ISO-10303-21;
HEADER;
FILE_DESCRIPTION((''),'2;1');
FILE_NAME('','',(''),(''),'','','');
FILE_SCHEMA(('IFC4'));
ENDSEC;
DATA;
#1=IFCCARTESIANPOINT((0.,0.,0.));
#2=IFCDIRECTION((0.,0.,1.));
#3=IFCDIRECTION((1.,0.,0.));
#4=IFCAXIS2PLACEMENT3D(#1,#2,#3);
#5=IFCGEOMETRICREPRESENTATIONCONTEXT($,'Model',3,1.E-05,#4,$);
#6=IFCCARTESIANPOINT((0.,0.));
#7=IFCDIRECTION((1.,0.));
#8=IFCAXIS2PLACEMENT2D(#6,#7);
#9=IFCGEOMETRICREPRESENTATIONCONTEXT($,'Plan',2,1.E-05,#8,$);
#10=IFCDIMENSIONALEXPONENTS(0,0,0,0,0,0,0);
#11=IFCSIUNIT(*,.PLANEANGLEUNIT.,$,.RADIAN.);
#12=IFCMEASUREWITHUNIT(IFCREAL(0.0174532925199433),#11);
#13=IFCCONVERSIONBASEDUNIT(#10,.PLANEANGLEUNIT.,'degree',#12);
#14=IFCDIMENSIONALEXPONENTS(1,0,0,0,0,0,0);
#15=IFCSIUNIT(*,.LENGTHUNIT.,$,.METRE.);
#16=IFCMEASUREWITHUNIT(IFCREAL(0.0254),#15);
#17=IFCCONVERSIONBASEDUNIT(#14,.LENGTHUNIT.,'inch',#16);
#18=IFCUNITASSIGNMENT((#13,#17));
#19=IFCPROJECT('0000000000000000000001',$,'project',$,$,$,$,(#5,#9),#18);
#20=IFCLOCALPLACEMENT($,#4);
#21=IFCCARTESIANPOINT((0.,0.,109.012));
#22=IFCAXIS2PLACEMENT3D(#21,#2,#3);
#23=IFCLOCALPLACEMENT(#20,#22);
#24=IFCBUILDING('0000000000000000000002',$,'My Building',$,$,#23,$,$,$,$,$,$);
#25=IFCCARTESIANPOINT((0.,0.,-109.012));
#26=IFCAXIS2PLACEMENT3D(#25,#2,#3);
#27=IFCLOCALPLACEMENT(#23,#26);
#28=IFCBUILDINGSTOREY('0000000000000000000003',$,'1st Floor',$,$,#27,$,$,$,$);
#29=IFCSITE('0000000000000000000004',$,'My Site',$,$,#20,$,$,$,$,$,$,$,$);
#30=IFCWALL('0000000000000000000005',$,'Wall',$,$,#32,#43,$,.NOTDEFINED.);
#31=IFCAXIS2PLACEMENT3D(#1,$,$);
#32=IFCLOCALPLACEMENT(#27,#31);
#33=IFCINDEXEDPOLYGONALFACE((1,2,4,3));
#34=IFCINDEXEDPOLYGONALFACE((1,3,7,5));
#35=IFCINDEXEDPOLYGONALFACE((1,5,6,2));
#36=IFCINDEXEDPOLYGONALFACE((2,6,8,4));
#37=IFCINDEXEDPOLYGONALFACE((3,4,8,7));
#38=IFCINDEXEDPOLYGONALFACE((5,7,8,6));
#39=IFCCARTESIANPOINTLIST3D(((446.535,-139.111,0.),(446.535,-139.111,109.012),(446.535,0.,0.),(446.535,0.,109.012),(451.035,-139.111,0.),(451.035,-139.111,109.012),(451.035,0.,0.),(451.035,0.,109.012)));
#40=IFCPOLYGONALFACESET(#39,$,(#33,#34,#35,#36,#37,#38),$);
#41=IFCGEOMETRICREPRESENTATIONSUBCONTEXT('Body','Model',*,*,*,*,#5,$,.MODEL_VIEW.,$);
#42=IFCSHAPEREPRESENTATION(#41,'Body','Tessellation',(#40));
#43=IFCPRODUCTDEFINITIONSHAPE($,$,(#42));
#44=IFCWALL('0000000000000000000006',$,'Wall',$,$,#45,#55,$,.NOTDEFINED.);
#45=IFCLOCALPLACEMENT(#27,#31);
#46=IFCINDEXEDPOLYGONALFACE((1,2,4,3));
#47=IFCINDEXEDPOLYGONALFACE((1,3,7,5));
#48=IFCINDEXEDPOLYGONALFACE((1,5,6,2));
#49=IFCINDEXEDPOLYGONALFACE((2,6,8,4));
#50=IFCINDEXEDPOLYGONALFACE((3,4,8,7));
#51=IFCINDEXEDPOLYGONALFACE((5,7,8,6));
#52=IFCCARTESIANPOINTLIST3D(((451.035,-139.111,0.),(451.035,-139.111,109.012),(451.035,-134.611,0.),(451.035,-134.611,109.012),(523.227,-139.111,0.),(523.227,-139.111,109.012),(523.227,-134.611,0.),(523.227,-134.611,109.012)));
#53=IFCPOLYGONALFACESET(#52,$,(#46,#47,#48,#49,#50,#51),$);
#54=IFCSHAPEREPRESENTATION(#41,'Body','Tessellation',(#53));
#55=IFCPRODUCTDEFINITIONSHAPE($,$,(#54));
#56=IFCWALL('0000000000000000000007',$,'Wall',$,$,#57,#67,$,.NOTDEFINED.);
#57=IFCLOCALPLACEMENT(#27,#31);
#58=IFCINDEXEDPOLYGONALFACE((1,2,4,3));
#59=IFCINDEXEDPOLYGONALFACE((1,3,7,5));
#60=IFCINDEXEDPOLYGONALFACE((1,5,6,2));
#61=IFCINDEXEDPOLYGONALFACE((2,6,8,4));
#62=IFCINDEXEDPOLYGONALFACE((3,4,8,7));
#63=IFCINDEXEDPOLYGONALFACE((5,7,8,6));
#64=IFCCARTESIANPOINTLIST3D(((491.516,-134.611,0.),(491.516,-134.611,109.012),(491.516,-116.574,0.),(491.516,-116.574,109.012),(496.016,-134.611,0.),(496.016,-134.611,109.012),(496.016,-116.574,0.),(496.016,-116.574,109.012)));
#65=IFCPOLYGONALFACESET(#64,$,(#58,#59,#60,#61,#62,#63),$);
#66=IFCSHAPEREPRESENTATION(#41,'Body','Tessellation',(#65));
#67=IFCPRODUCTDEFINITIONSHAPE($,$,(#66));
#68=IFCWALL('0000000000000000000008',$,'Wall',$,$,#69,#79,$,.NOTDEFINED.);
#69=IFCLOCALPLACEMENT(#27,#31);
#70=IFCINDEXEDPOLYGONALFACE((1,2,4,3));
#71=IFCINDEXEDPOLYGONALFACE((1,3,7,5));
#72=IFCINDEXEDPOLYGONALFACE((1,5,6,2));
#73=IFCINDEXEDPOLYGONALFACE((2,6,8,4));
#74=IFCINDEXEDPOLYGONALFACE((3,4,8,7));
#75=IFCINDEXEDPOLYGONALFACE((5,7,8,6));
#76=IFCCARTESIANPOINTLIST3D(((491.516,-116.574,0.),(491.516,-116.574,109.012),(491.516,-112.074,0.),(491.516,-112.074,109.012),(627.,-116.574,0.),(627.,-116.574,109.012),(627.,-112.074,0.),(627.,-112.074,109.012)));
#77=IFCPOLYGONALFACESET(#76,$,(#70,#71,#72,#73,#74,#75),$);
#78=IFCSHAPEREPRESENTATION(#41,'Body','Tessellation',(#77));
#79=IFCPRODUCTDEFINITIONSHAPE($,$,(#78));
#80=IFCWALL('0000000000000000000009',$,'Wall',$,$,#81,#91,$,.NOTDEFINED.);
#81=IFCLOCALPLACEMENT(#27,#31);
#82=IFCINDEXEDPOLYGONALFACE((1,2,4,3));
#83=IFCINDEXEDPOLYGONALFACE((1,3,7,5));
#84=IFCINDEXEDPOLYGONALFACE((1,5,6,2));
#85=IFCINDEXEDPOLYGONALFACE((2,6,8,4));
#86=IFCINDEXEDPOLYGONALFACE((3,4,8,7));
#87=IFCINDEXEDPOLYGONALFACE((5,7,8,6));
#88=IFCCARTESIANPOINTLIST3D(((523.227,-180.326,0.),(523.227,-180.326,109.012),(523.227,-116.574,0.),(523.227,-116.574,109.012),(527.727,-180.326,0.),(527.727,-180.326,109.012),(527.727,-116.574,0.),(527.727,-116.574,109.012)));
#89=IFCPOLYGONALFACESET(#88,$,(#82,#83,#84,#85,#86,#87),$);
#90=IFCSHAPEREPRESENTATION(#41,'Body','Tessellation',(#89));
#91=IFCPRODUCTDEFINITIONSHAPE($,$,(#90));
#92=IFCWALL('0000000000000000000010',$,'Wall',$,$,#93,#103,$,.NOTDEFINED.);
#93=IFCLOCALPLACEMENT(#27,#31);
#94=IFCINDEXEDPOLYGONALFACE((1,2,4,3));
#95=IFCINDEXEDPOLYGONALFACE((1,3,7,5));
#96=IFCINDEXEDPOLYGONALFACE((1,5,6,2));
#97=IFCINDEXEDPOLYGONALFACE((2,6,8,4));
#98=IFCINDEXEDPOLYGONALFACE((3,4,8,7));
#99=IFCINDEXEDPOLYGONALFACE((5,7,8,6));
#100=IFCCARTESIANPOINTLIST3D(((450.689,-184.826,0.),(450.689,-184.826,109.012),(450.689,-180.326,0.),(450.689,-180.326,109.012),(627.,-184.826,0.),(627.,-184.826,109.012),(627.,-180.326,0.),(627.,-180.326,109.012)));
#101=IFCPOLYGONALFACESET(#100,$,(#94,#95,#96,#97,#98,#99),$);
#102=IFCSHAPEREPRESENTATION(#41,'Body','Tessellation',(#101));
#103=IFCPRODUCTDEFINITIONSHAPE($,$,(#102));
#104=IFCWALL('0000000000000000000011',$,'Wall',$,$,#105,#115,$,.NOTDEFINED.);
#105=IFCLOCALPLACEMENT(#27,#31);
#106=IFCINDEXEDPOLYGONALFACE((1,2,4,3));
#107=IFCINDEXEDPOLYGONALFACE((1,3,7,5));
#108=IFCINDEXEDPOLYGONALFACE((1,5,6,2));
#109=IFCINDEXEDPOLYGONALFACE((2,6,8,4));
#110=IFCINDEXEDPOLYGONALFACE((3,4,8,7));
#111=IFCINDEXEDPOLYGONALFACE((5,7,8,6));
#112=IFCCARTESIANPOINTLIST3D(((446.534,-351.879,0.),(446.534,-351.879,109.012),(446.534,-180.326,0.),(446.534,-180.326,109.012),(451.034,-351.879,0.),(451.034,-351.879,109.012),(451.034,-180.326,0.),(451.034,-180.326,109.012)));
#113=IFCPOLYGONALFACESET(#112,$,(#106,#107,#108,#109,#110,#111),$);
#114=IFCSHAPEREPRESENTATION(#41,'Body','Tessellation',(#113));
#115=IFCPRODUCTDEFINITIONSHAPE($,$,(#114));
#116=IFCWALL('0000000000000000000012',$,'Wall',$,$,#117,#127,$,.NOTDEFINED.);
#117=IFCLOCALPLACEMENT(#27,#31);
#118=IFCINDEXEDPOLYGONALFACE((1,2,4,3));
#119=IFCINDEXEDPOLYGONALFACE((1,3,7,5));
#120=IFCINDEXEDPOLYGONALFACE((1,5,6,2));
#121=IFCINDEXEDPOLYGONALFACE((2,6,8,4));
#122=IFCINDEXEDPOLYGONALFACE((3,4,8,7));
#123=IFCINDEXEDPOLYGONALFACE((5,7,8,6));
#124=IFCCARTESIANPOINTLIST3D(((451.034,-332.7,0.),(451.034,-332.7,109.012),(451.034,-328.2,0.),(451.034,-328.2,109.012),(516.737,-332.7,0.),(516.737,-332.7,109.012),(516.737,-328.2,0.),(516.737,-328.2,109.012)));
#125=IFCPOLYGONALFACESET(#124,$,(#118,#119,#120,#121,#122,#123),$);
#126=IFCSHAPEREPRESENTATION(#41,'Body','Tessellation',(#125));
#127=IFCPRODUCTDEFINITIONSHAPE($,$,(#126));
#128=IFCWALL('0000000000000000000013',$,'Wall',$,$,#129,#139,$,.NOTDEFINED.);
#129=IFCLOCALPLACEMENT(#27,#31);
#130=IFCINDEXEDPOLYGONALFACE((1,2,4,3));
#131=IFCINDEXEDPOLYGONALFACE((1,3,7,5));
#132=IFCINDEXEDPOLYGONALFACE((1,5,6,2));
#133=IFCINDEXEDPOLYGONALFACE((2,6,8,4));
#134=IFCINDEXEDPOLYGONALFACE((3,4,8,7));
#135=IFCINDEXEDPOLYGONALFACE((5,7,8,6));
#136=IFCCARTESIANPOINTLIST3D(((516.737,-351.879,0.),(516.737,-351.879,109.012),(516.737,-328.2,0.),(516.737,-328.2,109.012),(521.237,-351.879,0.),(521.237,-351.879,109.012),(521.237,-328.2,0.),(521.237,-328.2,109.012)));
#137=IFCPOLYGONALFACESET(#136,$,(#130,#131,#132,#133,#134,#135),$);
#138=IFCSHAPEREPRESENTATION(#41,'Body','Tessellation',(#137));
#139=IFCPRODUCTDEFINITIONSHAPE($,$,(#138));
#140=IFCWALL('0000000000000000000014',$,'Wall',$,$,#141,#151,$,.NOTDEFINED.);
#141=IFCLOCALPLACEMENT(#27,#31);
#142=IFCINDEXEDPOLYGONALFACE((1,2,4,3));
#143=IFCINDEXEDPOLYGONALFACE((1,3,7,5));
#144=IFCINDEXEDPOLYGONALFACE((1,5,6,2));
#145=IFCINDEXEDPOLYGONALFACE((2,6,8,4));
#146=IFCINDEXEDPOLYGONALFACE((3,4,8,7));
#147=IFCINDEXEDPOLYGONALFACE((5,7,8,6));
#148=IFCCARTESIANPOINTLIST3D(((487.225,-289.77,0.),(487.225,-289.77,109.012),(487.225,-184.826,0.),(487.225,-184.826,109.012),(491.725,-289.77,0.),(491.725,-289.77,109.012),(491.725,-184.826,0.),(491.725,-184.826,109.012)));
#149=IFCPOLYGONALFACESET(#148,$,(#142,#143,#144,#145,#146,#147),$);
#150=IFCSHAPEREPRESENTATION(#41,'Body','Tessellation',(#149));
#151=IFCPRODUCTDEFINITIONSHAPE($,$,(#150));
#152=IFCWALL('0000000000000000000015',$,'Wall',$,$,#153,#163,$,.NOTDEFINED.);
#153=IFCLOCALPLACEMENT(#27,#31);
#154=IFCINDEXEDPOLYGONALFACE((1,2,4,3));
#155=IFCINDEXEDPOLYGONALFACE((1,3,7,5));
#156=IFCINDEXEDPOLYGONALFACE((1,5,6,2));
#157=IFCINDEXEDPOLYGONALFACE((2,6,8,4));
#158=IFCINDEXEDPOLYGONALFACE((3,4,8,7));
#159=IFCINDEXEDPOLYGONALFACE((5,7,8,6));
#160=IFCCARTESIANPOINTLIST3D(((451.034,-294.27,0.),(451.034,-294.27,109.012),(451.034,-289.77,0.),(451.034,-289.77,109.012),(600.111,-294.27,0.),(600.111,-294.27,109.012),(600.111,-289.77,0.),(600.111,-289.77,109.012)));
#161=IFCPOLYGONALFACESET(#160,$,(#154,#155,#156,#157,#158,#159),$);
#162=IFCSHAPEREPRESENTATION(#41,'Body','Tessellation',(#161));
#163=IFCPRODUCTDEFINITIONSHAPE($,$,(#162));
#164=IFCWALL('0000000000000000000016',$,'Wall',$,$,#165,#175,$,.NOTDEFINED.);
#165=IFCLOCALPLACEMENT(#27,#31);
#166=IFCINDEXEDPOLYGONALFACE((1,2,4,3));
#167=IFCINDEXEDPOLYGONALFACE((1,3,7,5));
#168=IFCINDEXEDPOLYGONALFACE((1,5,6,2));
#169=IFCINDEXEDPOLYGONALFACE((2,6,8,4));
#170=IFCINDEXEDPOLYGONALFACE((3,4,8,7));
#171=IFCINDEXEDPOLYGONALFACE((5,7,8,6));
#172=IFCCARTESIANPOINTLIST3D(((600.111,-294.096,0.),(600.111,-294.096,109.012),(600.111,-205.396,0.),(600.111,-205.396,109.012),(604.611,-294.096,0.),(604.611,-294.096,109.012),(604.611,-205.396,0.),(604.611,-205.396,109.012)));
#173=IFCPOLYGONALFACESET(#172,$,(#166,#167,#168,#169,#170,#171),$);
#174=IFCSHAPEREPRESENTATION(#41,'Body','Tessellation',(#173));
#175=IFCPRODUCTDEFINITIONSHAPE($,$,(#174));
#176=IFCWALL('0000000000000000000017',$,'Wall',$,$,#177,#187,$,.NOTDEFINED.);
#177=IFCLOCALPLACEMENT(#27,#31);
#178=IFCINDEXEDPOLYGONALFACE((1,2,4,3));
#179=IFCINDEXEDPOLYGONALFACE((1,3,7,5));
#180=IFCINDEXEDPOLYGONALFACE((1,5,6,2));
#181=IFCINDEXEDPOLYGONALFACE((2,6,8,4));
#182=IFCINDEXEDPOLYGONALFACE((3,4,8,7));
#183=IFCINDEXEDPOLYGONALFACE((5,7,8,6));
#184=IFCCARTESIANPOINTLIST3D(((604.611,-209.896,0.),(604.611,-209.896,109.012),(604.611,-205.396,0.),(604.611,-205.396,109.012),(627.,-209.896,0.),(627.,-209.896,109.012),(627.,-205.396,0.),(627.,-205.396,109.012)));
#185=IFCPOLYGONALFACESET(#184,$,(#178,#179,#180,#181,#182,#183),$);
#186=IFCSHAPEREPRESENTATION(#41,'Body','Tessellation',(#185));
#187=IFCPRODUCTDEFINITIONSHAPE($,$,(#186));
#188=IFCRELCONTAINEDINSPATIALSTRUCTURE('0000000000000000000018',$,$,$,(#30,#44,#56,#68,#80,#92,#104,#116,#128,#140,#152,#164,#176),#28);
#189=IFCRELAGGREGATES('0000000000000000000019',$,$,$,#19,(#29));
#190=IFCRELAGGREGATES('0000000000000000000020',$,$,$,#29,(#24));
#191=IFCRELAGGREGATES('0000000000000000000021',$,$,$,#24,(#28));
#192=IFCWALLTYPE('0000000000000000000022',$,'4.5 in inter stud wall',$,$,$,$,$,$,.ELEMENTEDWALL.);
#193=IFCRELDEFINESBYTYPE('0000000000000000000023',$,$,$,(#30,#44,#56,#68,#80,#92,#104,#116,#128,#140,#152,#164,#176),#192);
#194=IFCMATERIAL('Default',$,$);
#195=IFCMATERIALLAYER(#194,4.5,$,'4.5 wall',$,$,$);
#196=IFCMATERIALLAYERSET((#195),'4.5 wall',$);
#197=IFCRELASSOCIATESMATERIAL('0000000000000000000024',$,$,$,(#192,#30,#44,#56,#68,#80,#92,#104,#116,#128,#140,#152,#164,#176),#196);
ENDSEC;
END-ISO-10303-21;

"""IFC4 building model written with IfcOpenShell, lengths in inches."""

from ifc_helpers import new_model, entity, si_unit, converted_unit, frame, origin_with_axes, origin_2d_with_axis, place, context, subcontext, project, spatial, indexed_curve, outline, extrude, material, layer, layer_set, layer_usage, type_object, element, save


model = new_model("IFC4")

# Units and contexts
model_context = context("Model", 3, precision=1e-05, world=origin_with_axes())
plan_context = context("Plan", 2, precision=1e-05, world=origin_2d_with_axis())
body_context = subcontext(model_context, "Body", "Model", "MODEL_VIEW")
ifc_project = project(units=[converted_unit("PLANEANGLEUNIT", "degree", entity("IfcReal", 0.0174532925199433), si_unit("PLANEANGLEUNIT", "RADIAN"), dimensions=[0, 0, 0, 0, 0, 0, 0]), converted_unit("LENGTHUNIT", "inch", entity("IfcReal", 0.0254), si_unit("LENGTHUNIT", "METRE"), dimensions=[1, 0, 0, 0, 0, 0, 0])], contexts=[model_context, plan_context])

# Site, building, storey
site_placement = place(None, origin_with_axes())
site = spatial("IfcSite", under=ifc_project, at=site_placement, Name="My Site")
building_placement = place(site_placement, frame((0.0, 0.0, 109.012), z_axis=(0.0, 0.0, 1.0), x_axis=(1.0, 0.0, 0.0)))
building = spatial("IfcBuilding", under=site, at=building_placement, Name="My Building")
storey_placement = place(building_placement, frame((0.0, 0.0, -109.012), z_axis=(0.0, 0.0, 1.0), x_axis=(1.0, 0.0, 0.0)))
storey = spatial("IfcBuildingStorey", under=building, at=storey_placement, Name="1st Floor")

# Shared definitions
ifc_material = material(Name="Default")

# Walls
ifc_layer_1 = layer(ifc_material, 4.5, Name="4.5 wall")
ifc_layer_set_1 = layer_set([ifc_layer_1], Name="4.5 wall")
ifc_layer_usage_1 = layer_usage(ifc_layer_set_1, "AXIS2", "POSITIVE", 0.0)
wall_type_1 = type_object("IfcWallType", Name="4.5 in inter stud wall", PredefinedType="ELEMENTEDWALL", material=ifc_layer_set_1)
wall_1_placement = place(storey_placement, frame((446.535, 0.0, 0.0), z_axis=(0.0, 0.0, 1.0), x_axis=(0.0, -1.0, 0.0)))
element("IfcWall", 1, at=wall_1_placement, inside=storey, type_object=wall_type_1, material=ifc_layer_usage_1, Name="Wall", PredefinedType="NOTDEFINED", context=body_context, shape_type="SweptSolid", body=[
    extrude(outline(indexed_curve([(0.0, 0.0), (0.0, 4.5), (139.111, 4.5), (139.111, 0.0), (0.0, 0.0)], self_intersect=False)), origin_with_axes(), (0.0, 0.0, 1.0), 109.012),
])
ifc_layer_usage_2 = layer_usage(ifc_layer_set_1, "AXIS2", "POSITIVE", 0.0)
wall_2_placement = place(storey_placement, frame((451.035, -139.111, 0.0), z_axis=(0.0, 0.0, 1.0), x_axis=(1.0, 0.0, 0.0)))
element("IfcWall", 2, at=wall_2_placement, inside=storey, type_object=wall_type_1, material=ifc_layer_usage_2, Name="Wall", PredefinedType="NOTDEFINED", context=body_context, shape_type="SweptSolid", body=[
    extrude(outline(indexed_curve([(0.0, 0.0), (0.0, 4.5), (72.192, 4.5), (72.192, 0.0), (0.0, 0.0)], self_intersect=False)), origin_with_axes(), (0.0, 0.0, 1.0), 109.012),
])
ifc_layer_usage_3 = layer_usage(ifc_layer_set_1, "AXIS2", "POSITIVE", 0.0)
wall_3_placement = place(storey_placement, frame((496.016, -134.611, 0.0), z_axis=(0.0, 0.0, 1.0), x_axis=(0.0, 1.0, 0.0)))
element("IfcWall", 3, at=wall_3_placement, inside=storey, type_object=wall_type_1, material=ifc_layer_usage_3, Name="Wall", PredefinedType="NOTDEFINED", context=body_context, shape_type="SweptSolid", body=[
    extrude(outline(indexed_curve([(0.0, 0.0), (0.0, 4.5), (18.037, 4.5), (18.037, 0.0), (0.0, 0.0)], self_intersect=False)), origin_with_axes(), (0.0, 0.0, 1.0), 109.012),
])
ifc_layer_usage_4 = layer_usage(ifc_layer_set_1, "AXIS2", "POSITIVE", 0.0)
wall_4_placement = place(storey_placement, frame((491.516, -116.574, 0.0), z_axis=(0.0, 0.0, 1.0), x_axis=(1.0, 0.0, 0.0)))
element("IfcWall", 4, at=wall_4_placement, inside=storey, type_object=wall_type_1, material=ifc_layer_usage_4, Name="Wall", PredefinedType="NOTDEFINED", context=body_context, shape_type="SweptSolid", body=[
    extrude(outline(indexed_curve([(0.0, 0.0), (0.0, 4.5), (135.484, 4.5), (135.484, 0.0), (0.0, 0.0)], self_intersect=False)), origin_with_axes(), (0.0, 0.0, 1.0), 109.012),
])
ifc_layer_usage_5 = layer_usage(ifc_layer_set_1, "AXIS2", "POSITIVE", 0.0)
wall_5_placement = place(storey_placement, frame((523.227, -116.574, 0.0), z_axis=(0.0, 0.0, 1.0), x_axis=(0.0, -1.0, 0.0)))
element("IfcWall", 5, at=wall_5_placement, inside=storey, type_object=wall_type_1, material=ifc_layer_usage_5, Name="Wall", PredefinedType="NOTDEFINED", context=body_context, shape_type="SweptSolid", body=[
    extrude(outline(indexed_curve([(0.0, 0.0), (0.0, 4.5), (63.752, 4.5), (63.752, 0.0), (0.0, 0.0)], self_intersect=False)), origin_with_axes(), (0.0, 0.0, 1.0), 109.012),
])
ifc_layer_usage_6 = layer_usage(ifc_layer_set_1, "AXIS2", "POSITIVE", 0.0)
wall_6_placement = place(storey_placement, frame((627.0, -180.326, 0.0), z_axis=(0.0, 0.0, 1.0), x_axis=(-1.0, 0.000001, 0.0)))
element("IfcWall", 6, at=wall_6_placement, inside=storey, type_object=wall_type_1, material=ifc_layer_usage_6, Name="Wall", PredefinedType="NOTDEFINED", context=body_context, shape_type="SweptSolid", body=[
    extrude(outline(indexed_curve([(0.0, 0.0), (0.0, 4.5), (176.311, 4.5), (176.311, 0.0), (0.0, 0.0)], self_intersect=False)), origin_with_axes(), (0.0, 0.0, 1.0), 109.012),
])
ifc_layer_usage_7 = layer_usage(ifc_layer_set_1, "AXIS2", "POSITIVE", 0.0)
wall_7_placement = place(storey_placement, frame((451.034, -351.879, 0.0), z_axis=(0.0, 0.0, 1.0), x_axis=(0.000001, 1.0, 0.0)))
element("IfcWall", 7, at=wall_7_placement, inside=storey, type_object=wall_type_1, material=ifc_layer_usage_7, Name="Wall", PredefinedType="NOTDEFINED", context=body_context, shape_type="SweptSolid", body=[
    extrude(outline(indexed_curve([(0.0, 0.0), (0.0, 4.5), (171.553, 4.5), (171.553, 0.0), (0.0, 0.0)], self_intersect=False)), origin_with_axes(), (0.0, 0.0, 1.0), 109.012),
])
ifc_layer_usage_8 = layer_usage(ifc_layer_set_1, "AXIS2", "POSITIVE", 0.0)
wall_8_placement = place(storey_placement, frame((516.737, -328.2, 0.0), z_axis=(0.0, 0.0, 1.0), x_axis=(-1.0, 0.000001, 0.0)))
element("IfcWall", 8, at=wall_8_placement, inside=storey, type_object=wall_type_1, material=ifc_layer_usage_8, Name="Wall", PredefinedType="NOTDEFINED", context=body_context, shape_type="SweptSolid", body=[
    extrude(outline(indexed_curve([(0.0, 0.0), (0.0, 4.5), (65.703, 4.5), (65.703, 0.0), (0.0, 0.0)], self_intersect=False)), origin_with_axes(), (0.0, 0.0, 1.0), 109.012),
])
ifc_layer_usage_9 = layer_usage(ifc_layer_set_1, "AXIS2", "POSITIVE", 0.0)
wall_9_placement = place(storey_placement, frame((516.737, -328.2, 0.0), z_axis=(0.0, 0.0, 1.0), x_axis=(-0.000001, -1.0, 0.0)))
element("IfcWall", 9, at=wall_9_placement, inside=storey, type_object=wall_type_1, material=ifc_layer_usage_9, Name="Wall", PredefinedType="NOTDEFINED", context=body_context, shape_type="SweptSolid", body=[
    extrude(outline(indexed_curve([(0.0, 0.0), (0.0, 4.5), (23.679, 4.5), (23.679, 0.0), (0.0, 0.0)], self_intersect=False)), origin_with_axes(), (0.0, 0.0, 1.0), 109.012),
])
ifc_layer_usage_10 = layer_usage(ifc_layer_set_1, "AXIS2", "POSITIVE", 0.0)
wall_10_placement = place(storey_placement, frame((491.725, -289.77, 0.0), z_axis=(0.0, 0.0, 1.0), x_axis=(0.000001, 1.0, 0.0)))
element("IfcWall", 10, at=wall_10_placement, inside=storey, type_object=wall_type_1, material=ifc_layer_usage_10, Name="Wall", PredefinedType="NOTDEFINED", context=body_context, shape_type="SweptSolid", body=[
    extrude(outline(indexed_curve([(0.0, 0.0), (0.0, 4.5), (104.944, 4.5), (104.944, 0.0), (0.0, 0.0)], self_intersect=False)), origin_with_axes(), (0.0, 0.0, 1.0), 109.012),
])
ifc_layer_usage_11 = layer_usage(ifc_layer_set_1, "AXIS2", "POSITIVE", 0.0)
wall_11_placement = place(storey_placement, frame((600.111, -289.77, 0.0), z_axis=(0.0, 0.0, 1.0), x_axis=(-1.0, 0.0, 0.0)))
element("IfcWall", 11, at=wall_11_placement, inside=storey, type_object=wall_type_1, material=ifc_layer_usage_11, Name="Wall", PredefinedType="NOTDEFINED", context=body_context, shape_type="SweptSolid", body=[
    extrude(outline(indexed_curve([(0.0, 0.0), (0.0, 4.5), (149.076, 4.5), (149.076, 0.0), (0.0, 0.0)], self_intersect=False)), origin_with_axes(), (0.0, 0.0, 1.0), 109.012),
])
ifc_layer_usage_12 = layer_usage(ifc_layer_set_1, "AXIS2", "POSITIVE", 0.0)
wall_12_placement = place(storey_placement, frame((600.111, -205.396, 0.0), z_axis=(0.0, 0.0, 1.0), x_axis=(0.0, -1.0, 0.0)))
element("IfcWall", 12, at=wall_12_placement, inside=storey, type_object=wall_type_1, material=ifc_layer_usage_12, Name="Wall", PredefinedType="NOTDEFINED", context=body_context, shape_type="SweptSolid", body=[
    extrude(outline(indexed_curve([(0.0, 0.0), (0.0, 4.5), (88.7, 4.5), (88.7, 0.0), (0.0, 0.0)], self_intersect=False)), origin_with_axes(), (0.0, 0.0, 1.0), 109.012),
])
ifc_layer_usage_13 = layer_usage(ifc_layer_set_1, "AXIS2", "POSITIVE", 0.0)
wall_13_placement = place(storey_placement, frame((627.0, -205.396, 0.0), z_axis=(0.0, 0.0, 1.0), x_axis=(-1.0, 0.000001, 0.0)))
element("IfcWall", 13, at=wall_13_placement, inside=storey, type_object=wall_type_1, material=ifc_layer_usage_13, Name="Wall", PredefinedType="NOTDEFINED", context=body_context, shape_type="SweptSolid", body=[
    extrude(outline(indexed_curve([(0.0, 0.0), (0.0, 4.5), (22.389, 4.5), (22.389, 0.0), (0.0, 0.0)], self_intersect=False)), origin_with_axes(), (0.0, 0.0, 1.0), 109.012),
])

save(model, "model.ifc")
